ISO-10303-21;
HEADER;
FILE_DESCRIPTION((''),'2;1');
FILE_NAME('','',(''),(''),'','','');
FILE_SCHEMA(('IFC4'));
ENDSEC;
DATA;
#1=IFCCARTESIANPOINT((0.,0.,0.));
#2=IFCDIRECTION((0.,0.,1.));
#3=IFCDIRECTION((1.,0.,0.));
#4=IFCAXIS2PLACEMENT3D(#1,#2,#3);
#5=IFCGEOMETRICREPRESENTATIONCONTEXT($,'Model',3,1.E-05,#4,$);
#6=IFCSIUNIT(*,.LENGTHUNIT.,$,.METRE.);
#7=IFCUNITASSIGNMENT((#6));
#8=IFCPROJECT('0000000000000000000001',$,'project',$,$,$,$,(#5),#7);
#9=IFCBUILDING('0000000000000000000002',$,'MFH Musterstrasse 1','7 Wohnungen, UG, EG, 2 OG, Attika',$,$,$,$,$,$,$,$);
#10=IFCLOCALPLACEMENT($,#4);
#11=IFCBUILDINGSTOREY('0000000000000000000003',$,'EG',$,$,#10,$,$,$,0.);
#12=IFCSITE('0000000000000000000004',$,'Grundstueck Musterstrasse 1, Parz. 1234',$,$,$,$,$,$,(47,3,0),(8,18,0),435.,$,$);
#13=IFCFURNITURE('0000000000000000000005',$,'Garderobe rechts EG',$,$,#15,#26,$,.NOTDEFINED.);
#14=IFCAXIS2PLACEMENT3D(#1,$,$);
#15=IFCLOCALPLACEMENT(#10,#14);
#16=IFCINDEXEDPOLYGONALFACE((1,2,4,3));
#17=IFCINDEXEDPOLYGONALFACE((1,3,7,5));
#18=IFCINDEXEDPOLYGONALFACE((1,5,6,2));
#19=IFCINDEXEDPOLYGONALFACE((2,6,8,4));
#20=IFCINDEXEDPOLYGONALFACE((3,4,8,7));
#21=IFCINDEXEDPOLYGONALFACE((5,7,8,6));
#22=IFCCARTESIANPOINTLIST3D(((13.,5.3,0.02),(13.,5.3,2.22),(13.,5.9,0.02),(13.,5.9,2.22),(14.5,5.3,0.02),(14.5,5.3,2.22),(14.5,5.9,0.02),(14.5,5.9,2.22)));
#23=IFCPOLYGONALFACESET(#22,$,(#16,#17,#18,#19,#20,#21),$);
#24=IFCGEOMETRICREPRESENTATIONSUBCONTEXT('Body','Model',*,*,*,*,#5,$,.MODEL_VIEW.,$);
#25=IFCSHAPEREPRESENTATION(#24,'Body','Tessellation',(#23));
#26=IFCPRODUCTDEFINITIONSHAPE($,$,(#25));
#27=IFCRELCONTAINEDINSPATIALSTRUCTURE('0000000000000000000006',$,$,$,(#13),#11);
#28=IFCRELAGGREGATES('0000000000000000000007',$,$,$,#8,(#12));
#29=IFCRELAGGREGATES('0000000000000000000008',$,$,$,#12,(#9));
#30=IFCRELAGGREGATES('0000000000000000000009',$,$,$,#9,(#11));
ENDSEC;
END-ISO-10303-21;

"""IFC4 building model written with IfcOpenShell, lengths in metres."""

from ifc_helpers import new_model, si_unit, frame, frame_2d, origin_with_axes, place, context, subcontext, project, spatial, rectangle, extrude, element, save


model = new_model("IFC4")

# Units and contexts
model_context = context("Model", 3, precision=1e-05, world=origin_with_axes())
body_context = subcontext(model_context, "Body", "Model", "MODEL_VIEW")
ifc_project = project(units=[si_unit("LENGTHUNIT", "METRE")], contexts=[model_context])

# Site, building, storey
site = spatial("IfcSite", under=ifc_project, Name="Grundstueck Musterstrasse 1, Parz. 1234", RefLatitude=(47, 3, 0), RefLongitude=(8, 18, 0), RefElevation=435.0)
building = spatial("IfcBuilding", under=site, Name="MFH Musterstrasse 1", Description="7 Wohnungen, UG, EG, 2 OG, Attika")
storey_placement = place(None, origin_with_axes())
storey = spatial("IfcBuildingStorey", under=building, at=storey_placement, Name="EG", Elevation=0.0)

# Furniture
furniture_1_placement = place(storey_placement, frame((13.0, 5.3, 0.02), z_axis=(0.0, 0.0, 1.0), x_axis=(1.0, 0.0, 0.0)))
element("IfcFurniture", 1, at=furniture_1_placement, inside=storey, Name="Garderobe rechts EG", PredefinedType="NOTDEFINED", context=body_context, shape_type="SweptSolid", body=[
    extrude(rectangle(XDim=1.5, YDim=0.6, at=frame_2d((0.75, 0.3))), origin_with_axes(), (0.0, 0.0, 1.0), 2.2),
])

save(model, "model.ifc")
